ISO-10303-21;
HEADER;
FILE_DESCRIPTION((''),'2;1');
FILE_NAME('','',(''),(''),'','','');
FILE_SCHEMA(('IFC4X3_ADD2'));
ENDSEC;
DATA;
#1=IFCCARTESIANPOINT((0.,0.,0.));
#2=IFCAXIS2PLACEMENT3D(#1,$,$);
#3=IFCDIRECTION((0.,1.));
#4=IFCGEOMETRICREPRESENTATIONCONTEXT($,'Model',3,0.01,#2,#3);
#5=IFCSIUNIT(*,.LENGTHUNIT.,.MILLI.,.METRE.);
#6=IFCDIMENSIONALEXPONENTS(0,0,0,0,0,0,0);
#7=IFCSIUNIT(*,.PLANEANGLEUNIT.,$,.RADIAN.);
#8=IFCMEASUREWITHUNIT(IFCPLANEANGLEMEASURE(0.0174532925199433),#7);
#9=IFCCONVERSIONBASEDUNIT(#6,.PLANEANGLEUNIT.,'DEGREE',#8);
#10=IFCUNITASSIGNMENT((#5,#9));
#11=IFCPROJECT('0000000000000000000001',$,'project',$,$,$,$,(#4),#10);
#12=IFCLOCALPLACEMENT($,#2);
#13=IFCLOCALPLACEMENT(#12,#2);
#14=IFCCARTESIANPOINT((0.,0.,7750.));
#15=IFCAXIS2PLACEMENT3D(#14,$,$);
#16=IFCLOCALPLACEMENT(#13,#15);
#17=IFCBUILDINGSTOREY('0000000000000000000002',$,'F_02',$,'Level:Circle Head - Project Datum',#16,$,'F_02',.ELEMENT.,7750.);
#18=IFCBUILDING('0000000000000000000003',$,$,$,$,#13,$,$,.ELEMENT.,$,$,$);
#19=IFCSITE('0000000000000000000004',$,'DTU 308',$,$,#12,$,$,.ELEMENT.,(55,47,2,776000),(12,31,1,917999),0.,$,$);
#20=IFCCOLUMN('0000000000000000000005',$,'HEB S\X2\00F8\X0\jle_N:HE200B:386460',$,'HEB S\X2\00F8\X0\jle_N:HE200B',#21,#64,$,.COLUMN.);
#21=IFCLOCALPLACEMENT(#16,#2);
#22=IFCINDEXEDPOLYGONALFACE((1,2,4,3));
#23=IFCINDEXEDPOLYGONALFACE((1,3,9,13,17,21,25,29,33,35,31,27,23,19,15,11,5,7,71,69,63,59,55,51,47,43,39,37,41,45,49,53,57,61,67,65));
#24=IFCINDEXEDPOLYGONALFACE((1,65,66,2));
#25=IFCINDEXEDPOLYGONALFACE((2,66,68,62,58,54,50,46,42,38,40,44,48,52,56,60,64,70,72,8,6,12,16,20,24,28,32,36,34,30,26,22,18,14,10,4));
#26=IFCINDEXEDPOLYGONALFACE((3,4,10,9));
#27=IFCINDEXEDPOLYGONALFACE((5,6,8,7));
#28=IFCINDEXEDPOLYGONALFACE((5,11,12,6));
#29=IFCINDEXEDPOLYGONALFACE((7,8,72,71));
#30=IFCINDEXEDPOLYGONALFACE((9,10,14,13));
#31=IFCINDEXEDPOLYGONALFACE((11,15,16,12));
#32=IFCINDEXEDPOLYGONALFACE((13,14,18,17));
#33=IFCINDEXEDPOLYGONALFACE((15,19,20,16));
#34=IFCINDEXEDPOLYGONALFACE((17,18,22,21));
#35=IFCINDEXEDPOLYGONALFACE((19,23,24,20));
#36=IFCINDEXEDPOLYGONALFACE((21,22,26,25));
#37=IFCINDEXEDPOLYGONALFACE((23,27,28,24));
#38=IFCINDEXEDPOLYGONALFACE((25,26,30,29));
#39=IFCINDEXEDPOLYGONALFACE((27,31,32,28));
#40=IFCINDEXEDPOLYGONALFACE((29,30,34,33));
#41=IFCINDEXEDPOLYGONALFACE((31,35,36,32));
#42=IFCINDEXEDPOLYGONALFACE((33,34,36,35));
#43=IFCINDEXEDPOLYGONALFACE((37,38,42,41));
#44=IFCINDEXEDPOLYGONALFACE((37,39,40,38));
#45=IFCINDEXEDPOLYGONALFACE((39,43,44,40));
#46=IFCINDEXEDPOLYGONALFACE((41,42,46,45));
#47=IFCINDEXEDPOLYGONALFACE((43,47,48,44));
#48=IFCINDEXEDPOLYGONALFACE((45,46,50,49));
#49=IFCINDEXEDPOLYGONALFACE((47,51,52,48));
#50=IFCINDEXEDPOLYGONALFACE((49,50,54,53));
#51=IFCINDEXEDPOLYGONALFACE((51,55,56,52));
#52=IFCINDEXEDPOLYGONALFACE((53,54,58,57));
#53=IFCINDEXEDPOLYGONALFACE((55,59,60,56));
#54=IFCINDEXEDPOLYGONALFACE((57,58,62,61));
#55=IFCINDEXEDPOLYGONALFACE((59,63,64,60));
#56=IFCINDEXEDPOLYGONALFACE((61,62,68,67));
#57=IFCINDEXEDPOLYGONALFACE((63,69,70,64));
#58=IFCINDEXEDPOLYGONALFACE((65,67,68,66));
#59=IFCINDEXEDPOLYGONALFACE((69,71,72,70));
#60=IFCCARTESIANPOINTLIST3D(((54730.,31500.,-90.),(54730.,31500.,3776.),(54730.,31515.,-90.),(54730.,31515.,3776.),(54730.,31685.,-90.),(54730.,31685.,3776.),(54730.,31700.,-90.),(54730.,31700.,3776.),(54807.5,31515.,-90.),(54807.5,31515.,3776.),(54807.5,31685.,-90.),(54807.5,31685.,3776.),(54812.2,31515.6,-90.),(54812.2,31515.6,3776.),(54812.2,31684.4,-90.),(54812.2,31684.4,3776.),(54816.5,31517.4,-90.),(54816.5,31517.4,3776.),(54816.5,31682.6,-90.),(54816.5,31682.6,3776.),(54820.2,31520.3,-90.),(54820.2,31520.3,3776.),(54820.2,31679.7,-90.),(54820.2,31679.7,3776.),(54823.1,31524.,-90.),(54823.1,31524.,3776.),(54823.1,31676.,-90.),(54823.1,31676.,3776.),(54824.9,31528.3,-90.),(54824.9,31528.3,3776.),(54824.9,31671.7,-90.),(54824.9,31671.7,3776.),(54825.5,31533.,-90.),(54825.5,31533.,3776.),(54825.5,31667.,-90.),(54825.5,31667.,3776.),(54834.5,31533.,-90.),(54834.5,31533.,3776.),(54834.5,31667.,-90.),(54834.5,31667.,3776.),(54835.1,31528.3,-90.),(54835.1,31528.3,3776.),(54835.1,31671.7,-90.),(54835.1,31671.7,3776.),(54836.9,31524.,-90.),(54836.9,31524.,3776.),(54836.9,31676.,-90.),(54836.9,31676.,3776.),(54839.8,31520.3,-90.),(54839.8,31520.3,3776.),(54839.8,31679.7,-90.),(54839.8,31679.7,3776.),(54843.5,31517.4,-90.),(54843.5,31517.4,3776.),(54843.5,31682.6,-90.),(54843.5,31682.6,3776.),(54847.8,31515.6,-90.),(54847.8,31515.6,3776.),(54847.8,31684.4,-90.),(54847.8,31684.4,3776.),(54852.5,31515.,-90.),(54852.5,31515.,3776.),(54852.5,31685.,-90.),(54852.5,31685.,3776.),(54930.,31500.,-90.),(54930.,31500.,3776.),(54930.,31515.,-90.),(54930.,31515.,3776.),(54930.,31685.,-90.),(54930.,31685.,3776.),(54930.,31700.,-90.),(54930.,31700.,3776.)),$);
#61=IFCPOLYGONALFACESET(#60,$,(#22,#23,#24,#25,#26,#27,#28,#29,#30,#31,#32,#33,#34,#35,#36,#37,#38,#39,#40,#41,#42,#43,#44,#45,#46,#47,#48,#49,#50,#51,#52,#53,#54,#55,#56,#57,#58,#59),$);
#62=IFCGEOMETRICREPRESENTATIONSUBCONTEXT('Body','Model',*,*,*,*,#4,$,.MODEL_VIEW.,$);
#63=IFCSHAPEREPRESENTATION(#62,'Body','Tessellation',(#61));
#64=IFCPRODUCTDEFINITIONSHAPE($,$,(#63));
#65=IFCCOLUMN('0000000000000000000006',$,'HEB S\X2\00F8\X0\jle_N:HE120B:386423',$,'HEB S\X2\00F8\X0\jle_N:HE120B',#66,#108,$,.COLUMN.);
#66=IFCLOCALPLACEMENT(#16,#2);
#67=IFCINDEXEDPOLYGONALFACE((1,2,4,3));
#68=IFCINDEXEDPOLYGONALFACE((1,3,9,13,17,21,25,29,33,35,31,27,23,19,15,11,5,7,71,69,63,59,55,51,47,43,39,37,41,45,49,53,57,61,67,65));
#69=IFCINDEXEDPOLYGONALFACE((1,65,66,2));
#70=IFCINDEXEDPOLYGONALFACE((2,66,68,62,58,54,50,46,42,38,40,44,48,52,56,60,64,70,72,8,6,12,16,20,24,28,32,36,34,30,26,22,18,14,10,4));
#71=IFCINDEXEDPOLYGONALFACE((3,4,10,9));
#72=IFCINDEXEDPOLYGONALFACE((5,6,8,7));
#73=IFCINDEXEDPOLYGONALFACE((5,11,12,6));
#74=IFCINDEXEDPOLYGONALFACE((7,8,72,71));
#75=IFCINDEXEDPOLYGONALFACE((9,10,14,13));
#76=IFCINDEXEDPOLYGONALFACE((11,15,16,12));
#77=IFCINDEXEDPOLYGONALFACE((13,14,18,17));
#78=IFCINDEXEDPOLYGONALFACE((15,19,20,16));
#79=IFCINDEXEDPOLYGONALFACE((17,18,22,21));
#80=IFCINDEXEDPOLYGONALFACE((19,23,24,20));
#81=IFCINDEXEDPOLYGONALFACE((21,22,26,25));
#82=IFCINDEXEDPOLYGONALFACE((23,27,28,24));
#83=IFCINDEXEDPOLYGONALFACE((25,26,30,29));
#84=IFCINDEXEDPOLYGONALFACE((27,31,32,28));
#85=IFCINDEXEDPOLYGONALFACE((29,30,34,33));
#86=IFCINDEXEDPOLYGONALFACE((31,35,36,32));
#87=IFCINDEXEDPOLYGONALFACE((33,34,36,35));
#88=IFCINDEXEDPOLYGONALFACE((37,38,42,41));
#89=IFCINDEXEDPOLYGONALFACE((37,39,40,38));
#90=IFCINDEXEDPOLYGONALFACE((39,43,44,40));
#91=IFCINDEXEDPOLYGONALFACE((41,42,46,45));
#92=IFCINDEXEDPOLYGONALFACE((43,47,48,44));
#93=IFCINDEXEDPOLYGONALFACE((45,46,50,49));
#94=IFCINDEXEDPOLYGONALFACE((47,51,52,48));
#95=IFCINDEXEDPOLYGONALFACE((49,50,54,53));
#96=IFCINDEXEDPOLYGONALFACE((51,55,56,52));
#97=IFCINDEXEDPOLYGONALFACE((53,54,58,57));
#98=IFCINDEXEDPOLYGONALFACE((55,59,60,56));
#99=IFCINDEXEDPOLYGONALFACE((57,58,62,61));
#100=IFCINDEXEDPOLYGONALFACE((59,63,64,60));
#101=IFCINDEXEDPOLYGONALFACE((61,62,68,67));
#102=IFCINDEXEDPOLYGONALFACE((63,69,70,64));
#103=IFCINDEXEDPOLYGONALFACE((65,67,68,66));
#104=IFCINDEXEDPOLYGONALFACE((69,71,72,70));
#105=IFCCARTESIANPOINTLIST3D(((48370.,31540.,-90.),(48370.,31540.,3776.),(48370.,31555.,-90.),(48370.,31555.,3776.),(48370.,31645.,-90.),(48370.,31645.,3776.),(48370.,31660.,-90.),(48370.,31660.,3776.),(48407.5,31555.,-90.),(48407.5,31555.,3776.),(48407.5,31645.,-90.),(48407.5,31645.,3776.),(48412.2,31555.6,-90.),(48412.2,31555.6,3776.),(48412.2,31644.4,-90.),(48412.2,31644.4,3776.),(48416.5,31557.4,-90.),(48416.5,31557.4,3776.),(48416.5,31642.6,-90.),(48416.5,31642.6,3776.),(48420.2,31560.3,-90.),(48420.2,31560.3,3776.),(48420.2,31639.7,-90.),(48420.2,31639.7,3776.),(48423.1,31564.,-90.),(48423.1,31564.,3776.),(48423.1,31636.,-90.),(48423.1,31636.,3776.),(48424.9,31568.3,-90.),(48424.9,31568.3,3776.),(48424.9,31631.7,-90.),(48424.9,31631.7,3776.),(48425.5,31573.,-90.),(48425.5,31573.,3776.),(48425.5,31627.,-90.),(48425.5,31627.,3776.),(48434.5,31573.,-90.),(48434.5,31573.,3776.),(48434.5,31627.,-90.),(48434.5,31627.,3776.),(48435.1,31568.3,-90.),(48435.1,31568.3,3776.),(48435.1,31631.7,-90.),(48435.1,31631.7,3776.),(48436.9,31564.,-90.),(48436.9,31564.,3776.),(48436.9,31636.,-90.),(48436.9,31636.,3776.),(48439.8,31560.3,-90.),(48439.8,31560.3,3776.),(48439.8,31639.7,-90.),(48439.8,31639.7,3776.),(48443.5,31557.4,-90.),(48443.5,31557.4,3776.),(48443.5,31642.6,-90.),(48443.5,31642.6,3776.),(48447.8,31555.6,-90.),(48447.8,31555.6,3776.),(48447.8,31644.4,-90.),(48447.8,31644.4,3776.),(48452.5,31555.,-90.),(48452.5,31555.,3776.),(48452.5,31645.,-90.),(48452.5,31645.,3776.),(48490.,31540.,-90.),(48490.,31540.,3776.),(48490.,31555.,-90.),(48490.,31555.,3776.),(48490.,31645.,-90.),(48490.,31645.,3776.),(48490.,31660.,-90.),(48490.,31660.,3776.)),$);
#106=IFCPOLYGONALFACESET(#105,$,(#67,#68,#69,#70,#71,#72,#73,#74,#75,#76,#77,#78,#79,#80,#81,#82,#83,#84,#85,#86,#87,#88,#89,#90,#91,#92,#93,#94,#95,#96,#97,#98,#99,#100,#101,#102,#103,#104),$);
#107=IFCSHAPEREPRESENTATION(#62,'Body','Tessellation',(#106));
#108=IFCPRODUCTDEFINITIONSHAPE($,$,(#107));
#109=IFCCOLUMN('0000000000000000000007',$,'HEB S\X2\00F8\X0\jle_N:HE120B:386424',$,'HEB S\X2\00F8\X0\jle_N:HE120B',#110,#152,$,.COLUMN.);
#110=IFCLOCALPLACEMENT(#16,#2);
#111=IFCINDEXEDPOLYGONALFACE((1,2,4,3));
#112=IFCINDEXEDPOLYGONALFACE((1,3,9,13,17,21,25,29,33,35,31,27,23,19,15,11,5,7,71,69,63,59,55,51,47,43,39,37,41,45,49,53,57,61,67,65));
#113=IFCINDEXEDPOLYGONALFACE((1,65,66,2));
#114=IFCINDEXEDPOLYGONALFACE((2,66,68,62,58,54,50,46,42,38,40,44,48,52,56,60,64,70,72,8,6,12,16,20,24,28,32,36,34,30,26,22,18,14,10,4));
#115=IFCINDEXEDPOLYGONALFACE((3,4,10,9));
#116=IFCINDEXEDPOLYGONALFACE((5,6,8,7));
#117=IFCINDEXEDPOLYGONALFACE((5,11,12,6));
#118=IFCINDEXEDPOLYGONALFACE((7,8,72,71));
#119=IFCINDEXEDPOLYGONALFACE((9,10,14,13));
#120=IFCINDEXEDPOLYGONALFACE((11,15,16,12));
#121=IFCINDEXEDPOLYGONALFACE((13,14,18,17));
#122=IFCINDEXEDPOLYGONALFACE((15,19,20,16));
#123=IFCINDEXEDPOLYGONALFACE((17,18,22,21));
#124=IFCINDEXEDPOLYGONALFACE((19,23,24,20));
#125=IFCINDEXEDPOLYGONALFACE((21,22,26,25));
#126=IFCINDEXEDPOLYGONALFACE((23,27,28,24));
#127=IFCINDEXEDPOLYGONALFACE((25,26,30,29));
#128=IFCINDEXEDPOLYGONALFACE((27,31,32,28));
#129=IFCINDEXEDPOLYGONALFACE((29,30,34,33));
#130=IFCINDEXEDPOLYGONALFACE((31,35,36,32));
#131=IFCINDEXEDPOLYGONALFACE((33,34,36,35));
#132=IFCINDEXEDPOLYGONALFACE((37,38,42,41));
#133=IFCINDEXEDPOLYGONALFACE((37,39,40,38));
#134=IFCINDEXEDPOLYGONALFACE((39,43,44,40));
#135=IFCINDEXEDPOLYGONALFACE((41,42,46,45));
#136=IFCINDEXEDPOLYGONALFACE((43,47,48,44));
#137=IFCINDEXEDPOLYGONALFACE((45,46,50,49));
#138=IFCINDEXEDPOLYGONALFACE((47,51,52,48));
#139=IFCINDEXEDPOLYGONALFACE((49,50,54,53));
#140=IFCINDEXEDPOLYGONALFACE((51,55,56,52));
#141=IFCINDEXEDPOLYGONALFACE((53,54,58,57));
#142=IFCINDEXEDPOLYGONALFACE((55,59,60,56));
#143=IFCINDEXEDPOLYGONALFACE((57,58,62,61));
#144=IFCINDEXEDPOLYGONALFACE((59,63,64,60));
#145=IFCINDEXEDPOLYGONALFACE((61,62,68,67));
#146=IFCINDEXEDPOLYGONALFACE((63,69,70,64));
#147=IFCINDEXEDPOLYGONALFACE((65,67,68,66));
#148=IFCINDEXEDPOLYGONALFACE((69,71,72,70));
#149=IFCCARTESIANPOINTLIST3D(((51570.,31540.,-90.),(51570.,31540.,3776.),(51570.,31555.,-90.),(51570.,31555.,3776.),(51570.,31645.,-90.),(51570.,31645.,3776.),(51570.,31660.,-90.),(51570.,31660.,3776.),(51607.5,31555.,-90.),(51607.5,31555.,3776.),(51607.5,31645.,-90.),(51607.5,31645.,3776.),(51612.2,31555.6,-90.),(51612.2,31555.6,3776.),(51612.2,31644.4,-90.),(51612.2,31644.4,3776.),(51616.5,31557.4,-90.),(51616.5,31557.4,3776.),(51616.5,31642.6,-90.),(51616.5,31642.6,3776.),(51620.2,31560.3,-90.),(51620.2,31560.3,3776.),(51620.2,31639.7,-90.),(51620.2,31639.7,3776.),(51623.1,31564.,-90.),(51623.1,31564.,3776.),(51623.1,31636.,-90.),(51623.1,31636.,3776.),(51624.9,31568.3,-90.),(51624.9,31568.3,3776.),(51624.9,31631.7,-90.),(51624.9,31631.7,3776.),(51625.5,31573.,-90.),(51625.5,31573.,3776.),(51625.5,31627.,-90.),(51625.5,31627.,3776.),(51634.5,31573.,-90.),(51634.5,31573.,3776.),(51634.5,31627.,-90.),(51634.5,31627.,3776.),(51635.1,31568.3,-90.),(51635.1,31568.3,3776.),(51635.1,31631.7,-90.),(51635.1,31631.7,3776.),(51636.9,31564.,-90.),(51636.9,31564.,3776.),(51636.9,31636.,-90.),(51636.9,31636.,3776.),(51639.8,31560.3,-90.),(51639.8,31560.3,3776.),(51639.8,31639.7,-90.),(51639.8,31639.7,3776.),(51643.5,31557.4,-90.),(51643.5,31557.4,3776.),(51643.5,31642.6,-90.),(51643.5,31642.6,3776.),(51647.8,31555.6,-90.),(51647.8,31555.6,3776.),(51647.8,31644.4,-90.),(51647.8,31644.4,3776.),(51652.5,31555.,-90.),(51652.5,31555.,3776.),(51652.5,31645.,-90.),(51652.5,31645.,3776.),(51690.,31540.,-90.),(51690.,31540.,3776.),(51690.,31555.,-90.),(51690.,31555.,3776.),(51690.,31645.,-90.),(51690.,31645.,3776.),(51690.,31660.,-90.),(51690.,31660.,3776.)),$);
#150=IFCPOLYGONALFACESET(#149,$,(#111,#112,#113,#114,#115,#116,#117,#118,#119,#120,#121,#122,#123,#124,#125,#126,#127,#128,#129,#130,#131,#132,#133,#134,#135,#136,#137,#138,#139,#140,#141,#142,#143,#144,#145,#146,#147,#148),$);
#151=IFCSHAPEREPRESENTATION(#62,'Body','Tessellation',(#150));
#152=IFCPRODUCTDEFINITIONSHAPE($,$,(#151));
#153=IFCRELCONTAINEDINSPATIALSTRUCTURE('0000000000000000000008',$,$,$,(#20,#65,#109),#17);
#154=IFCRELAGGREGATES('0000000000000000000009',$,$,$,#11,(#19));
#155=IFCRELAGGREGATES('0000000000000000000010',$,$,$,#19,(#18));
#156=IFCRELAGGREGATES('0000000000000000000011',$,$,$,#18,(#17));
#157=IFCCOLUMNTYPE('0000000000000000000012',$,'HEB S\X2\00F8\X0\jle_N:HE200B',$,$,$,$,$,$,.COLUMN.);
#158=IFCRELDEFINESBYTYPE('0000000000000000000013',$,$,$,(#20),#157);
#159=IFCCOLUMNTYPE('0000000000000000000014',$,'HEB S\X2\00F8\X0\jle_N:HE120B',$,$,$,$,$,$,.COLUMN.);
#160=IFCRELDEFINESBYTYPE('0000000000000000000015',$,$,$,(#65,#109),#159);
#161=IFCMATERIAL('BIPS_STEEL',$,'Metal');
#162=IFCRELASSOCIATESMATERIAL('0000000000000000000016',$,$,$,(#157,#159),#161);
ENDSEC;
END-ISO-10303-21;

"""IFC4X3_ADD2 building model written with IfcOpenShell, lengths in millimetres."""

from ifc_helpers import new_model, entity, si_unit, converted_unit, direction, frame, frame_2d, origin, place, context, subcontext, project, spatial, i_section, extrude, source, transform, mapped, material, material_profile, profile_set, type_object, element, save


model = new_model("IFC4X3_ADD2")

# Units and contexts
model_context = context("Model", 3, precision=0.01, world=origin(), true_north=direction((0.0, 1.0)))
body_context = subcontext(model_context, "Body", "Model", "MODEL_VIEW")
ifc_project = project(units=[si_unit("LENGTHUNIT", "METRE", prefix="MILLI"), converted_unit("PLANEANGLEUNIT", "DEGREE", entity("IfcPlaneAngleMeasure", 0.0174532925199433), si_unit("PLANEANGLEUNIT", "RADIAN"), dimensions=[0, 0, 0, 0, 0, 0, 0])], contexts=[model_context])

# Site, building, storey
site_placement = place(None, origin())
site = spatial("IfcSite", under=ifc_project, at=site_placement, Name="DTU 308", CompositionType="ELEMENT", RefLatitude=(55, 47, 2, 776000), RefLongitude=(12, 31, 1, 917999), RefElevation=0.0)
building_placement = place(site_placement, origin())
building = spatial("IfcBuilding", under=site, at=building_placement, CompositionType="ELEMENT")
storey_placement = place(building_placement, frame((0.0, 0.0, 7750.0)))
storey = spatial("IfcBuildingStorey", under=building, at=storey_placement, Name="F_02", ObjectType="Level:Circle Head - Project Datum", LongName="F_02", CompositionType="ELEMENT", Elevation=7750.0)

# Columns
ifc_material = material(Name="BIPS_STEEL", Category="Metal")
ifc_material_profile_1 = material_profile(ifc_material, i_section(OverallWidth=200.0, OverallDepth=200.0, WebThickness=9.0, FlangeThickness=15.0, FilletRadius=18.0, at=frame_2d((0.0, 0.0), x_axis=(1.0, 0.0))), Name="HE200B")
ifc_profile_set_1 = profile_set([ifc_material_profile_1], Name="HE200B")
column_type_1 = type_object("IfcColumnType", Name="HEB Søjle_N:HE200B", PredefinedType="COLUMN", material=ifc_profile_set_1)
shared_shape_1 = source(origin(), body_context, "Body", "SweptSolid", [
    extrude(i_section(OverallWidth=200.0, OverallDepth=200.0, WebThickness=9.0, FlangeThickness=15.0, FilletRadius=18.0, at=frame_2d((0.0, 0.0), x_axis=(1.0, 0.0))), frame((0.0, 0.0, 7660.0), z_axis=(0.0, 0.0, 1.0), x_axis=(-1.0, 0.0, 0.0)), (0.0, 0.0, 1.0), 3866.0),
])
column_1_placement = place(storey_placement, frame((54830.0, 31600.0, -7750.0)))
element("IfcColumn", 1, at=column_1_placement, inside=storey, type_object=column_type_1, Name="HEB Søjle_N:HE200B:386460", ObjectType="HEB Søjle_N:HE200B", PredefinedType="COLUMN", context=body_context, shape_type="MappedRepresentation", body=[
    mapped(shared_shape_1, transform((0.0, 0.0, 0.0), scale=1.0)),
])
ifc_material_profile_2 = material_profile(ifc_material, i_section(OverallWidth=120.0, OverallDepth=120.0, WebThickness=9.0, FlangeThickness=15.0, FilletRadius=18.0, at=frame_2d((0.0, 0.0), x_axis=(1.0, 0.0))), Name="HE120B")
ifc_profile_set_2 = profile_set([ifc_material_profile_2], Name="HE120B")
column_type_2 = type_object("IfcColumnType", Name="HEB Søjle_N:HE120B", PredefinedType="COLUMN", material=ifc_profile_set_2)
shared_shape_2 = source(origin(), body_context, "Body", "SweptSolid", [
    extrude(i_section(OverallWidth=120.0, OverallDepth=120.0, WebThickness=9.0, FlangeThickness=15.0, FilletRadius=18.0, at=frame_2d((0.0, 0.0), x_axis=(1.0, 0.0))), frame((0.0, 0.0, 7660.0), z_axis=(0.0, 0.0, 1.0), x_axis=(-1.0, 0.0, 0.0)), (0.0, 0.0, 1.0), 3866.0),
])
for number, where, name in (
    (2, (48430.0, 31600.0, -7750.0), "HEB Søjle_N:HE120B:386423"),
    (3, (51630.0, 31600.0, -7750.0), "HEB Søjle_N:HE120B:386424"),
):
    element("IfcColumn", number, at=place(storey_placement, frame(where)), inside=storey, type_object=column_type_2, Name=name, ObjectType="HEB Søjle_N:HE120B", PredefinedType="COLUMN", context=body_context, shape_type="MappedRepresentation", body=[
        mapped(shared_shape_2, transform((0.0, 0.0, 0.0), scale=1.0)),
    ])

save(model, "model.ifc")
